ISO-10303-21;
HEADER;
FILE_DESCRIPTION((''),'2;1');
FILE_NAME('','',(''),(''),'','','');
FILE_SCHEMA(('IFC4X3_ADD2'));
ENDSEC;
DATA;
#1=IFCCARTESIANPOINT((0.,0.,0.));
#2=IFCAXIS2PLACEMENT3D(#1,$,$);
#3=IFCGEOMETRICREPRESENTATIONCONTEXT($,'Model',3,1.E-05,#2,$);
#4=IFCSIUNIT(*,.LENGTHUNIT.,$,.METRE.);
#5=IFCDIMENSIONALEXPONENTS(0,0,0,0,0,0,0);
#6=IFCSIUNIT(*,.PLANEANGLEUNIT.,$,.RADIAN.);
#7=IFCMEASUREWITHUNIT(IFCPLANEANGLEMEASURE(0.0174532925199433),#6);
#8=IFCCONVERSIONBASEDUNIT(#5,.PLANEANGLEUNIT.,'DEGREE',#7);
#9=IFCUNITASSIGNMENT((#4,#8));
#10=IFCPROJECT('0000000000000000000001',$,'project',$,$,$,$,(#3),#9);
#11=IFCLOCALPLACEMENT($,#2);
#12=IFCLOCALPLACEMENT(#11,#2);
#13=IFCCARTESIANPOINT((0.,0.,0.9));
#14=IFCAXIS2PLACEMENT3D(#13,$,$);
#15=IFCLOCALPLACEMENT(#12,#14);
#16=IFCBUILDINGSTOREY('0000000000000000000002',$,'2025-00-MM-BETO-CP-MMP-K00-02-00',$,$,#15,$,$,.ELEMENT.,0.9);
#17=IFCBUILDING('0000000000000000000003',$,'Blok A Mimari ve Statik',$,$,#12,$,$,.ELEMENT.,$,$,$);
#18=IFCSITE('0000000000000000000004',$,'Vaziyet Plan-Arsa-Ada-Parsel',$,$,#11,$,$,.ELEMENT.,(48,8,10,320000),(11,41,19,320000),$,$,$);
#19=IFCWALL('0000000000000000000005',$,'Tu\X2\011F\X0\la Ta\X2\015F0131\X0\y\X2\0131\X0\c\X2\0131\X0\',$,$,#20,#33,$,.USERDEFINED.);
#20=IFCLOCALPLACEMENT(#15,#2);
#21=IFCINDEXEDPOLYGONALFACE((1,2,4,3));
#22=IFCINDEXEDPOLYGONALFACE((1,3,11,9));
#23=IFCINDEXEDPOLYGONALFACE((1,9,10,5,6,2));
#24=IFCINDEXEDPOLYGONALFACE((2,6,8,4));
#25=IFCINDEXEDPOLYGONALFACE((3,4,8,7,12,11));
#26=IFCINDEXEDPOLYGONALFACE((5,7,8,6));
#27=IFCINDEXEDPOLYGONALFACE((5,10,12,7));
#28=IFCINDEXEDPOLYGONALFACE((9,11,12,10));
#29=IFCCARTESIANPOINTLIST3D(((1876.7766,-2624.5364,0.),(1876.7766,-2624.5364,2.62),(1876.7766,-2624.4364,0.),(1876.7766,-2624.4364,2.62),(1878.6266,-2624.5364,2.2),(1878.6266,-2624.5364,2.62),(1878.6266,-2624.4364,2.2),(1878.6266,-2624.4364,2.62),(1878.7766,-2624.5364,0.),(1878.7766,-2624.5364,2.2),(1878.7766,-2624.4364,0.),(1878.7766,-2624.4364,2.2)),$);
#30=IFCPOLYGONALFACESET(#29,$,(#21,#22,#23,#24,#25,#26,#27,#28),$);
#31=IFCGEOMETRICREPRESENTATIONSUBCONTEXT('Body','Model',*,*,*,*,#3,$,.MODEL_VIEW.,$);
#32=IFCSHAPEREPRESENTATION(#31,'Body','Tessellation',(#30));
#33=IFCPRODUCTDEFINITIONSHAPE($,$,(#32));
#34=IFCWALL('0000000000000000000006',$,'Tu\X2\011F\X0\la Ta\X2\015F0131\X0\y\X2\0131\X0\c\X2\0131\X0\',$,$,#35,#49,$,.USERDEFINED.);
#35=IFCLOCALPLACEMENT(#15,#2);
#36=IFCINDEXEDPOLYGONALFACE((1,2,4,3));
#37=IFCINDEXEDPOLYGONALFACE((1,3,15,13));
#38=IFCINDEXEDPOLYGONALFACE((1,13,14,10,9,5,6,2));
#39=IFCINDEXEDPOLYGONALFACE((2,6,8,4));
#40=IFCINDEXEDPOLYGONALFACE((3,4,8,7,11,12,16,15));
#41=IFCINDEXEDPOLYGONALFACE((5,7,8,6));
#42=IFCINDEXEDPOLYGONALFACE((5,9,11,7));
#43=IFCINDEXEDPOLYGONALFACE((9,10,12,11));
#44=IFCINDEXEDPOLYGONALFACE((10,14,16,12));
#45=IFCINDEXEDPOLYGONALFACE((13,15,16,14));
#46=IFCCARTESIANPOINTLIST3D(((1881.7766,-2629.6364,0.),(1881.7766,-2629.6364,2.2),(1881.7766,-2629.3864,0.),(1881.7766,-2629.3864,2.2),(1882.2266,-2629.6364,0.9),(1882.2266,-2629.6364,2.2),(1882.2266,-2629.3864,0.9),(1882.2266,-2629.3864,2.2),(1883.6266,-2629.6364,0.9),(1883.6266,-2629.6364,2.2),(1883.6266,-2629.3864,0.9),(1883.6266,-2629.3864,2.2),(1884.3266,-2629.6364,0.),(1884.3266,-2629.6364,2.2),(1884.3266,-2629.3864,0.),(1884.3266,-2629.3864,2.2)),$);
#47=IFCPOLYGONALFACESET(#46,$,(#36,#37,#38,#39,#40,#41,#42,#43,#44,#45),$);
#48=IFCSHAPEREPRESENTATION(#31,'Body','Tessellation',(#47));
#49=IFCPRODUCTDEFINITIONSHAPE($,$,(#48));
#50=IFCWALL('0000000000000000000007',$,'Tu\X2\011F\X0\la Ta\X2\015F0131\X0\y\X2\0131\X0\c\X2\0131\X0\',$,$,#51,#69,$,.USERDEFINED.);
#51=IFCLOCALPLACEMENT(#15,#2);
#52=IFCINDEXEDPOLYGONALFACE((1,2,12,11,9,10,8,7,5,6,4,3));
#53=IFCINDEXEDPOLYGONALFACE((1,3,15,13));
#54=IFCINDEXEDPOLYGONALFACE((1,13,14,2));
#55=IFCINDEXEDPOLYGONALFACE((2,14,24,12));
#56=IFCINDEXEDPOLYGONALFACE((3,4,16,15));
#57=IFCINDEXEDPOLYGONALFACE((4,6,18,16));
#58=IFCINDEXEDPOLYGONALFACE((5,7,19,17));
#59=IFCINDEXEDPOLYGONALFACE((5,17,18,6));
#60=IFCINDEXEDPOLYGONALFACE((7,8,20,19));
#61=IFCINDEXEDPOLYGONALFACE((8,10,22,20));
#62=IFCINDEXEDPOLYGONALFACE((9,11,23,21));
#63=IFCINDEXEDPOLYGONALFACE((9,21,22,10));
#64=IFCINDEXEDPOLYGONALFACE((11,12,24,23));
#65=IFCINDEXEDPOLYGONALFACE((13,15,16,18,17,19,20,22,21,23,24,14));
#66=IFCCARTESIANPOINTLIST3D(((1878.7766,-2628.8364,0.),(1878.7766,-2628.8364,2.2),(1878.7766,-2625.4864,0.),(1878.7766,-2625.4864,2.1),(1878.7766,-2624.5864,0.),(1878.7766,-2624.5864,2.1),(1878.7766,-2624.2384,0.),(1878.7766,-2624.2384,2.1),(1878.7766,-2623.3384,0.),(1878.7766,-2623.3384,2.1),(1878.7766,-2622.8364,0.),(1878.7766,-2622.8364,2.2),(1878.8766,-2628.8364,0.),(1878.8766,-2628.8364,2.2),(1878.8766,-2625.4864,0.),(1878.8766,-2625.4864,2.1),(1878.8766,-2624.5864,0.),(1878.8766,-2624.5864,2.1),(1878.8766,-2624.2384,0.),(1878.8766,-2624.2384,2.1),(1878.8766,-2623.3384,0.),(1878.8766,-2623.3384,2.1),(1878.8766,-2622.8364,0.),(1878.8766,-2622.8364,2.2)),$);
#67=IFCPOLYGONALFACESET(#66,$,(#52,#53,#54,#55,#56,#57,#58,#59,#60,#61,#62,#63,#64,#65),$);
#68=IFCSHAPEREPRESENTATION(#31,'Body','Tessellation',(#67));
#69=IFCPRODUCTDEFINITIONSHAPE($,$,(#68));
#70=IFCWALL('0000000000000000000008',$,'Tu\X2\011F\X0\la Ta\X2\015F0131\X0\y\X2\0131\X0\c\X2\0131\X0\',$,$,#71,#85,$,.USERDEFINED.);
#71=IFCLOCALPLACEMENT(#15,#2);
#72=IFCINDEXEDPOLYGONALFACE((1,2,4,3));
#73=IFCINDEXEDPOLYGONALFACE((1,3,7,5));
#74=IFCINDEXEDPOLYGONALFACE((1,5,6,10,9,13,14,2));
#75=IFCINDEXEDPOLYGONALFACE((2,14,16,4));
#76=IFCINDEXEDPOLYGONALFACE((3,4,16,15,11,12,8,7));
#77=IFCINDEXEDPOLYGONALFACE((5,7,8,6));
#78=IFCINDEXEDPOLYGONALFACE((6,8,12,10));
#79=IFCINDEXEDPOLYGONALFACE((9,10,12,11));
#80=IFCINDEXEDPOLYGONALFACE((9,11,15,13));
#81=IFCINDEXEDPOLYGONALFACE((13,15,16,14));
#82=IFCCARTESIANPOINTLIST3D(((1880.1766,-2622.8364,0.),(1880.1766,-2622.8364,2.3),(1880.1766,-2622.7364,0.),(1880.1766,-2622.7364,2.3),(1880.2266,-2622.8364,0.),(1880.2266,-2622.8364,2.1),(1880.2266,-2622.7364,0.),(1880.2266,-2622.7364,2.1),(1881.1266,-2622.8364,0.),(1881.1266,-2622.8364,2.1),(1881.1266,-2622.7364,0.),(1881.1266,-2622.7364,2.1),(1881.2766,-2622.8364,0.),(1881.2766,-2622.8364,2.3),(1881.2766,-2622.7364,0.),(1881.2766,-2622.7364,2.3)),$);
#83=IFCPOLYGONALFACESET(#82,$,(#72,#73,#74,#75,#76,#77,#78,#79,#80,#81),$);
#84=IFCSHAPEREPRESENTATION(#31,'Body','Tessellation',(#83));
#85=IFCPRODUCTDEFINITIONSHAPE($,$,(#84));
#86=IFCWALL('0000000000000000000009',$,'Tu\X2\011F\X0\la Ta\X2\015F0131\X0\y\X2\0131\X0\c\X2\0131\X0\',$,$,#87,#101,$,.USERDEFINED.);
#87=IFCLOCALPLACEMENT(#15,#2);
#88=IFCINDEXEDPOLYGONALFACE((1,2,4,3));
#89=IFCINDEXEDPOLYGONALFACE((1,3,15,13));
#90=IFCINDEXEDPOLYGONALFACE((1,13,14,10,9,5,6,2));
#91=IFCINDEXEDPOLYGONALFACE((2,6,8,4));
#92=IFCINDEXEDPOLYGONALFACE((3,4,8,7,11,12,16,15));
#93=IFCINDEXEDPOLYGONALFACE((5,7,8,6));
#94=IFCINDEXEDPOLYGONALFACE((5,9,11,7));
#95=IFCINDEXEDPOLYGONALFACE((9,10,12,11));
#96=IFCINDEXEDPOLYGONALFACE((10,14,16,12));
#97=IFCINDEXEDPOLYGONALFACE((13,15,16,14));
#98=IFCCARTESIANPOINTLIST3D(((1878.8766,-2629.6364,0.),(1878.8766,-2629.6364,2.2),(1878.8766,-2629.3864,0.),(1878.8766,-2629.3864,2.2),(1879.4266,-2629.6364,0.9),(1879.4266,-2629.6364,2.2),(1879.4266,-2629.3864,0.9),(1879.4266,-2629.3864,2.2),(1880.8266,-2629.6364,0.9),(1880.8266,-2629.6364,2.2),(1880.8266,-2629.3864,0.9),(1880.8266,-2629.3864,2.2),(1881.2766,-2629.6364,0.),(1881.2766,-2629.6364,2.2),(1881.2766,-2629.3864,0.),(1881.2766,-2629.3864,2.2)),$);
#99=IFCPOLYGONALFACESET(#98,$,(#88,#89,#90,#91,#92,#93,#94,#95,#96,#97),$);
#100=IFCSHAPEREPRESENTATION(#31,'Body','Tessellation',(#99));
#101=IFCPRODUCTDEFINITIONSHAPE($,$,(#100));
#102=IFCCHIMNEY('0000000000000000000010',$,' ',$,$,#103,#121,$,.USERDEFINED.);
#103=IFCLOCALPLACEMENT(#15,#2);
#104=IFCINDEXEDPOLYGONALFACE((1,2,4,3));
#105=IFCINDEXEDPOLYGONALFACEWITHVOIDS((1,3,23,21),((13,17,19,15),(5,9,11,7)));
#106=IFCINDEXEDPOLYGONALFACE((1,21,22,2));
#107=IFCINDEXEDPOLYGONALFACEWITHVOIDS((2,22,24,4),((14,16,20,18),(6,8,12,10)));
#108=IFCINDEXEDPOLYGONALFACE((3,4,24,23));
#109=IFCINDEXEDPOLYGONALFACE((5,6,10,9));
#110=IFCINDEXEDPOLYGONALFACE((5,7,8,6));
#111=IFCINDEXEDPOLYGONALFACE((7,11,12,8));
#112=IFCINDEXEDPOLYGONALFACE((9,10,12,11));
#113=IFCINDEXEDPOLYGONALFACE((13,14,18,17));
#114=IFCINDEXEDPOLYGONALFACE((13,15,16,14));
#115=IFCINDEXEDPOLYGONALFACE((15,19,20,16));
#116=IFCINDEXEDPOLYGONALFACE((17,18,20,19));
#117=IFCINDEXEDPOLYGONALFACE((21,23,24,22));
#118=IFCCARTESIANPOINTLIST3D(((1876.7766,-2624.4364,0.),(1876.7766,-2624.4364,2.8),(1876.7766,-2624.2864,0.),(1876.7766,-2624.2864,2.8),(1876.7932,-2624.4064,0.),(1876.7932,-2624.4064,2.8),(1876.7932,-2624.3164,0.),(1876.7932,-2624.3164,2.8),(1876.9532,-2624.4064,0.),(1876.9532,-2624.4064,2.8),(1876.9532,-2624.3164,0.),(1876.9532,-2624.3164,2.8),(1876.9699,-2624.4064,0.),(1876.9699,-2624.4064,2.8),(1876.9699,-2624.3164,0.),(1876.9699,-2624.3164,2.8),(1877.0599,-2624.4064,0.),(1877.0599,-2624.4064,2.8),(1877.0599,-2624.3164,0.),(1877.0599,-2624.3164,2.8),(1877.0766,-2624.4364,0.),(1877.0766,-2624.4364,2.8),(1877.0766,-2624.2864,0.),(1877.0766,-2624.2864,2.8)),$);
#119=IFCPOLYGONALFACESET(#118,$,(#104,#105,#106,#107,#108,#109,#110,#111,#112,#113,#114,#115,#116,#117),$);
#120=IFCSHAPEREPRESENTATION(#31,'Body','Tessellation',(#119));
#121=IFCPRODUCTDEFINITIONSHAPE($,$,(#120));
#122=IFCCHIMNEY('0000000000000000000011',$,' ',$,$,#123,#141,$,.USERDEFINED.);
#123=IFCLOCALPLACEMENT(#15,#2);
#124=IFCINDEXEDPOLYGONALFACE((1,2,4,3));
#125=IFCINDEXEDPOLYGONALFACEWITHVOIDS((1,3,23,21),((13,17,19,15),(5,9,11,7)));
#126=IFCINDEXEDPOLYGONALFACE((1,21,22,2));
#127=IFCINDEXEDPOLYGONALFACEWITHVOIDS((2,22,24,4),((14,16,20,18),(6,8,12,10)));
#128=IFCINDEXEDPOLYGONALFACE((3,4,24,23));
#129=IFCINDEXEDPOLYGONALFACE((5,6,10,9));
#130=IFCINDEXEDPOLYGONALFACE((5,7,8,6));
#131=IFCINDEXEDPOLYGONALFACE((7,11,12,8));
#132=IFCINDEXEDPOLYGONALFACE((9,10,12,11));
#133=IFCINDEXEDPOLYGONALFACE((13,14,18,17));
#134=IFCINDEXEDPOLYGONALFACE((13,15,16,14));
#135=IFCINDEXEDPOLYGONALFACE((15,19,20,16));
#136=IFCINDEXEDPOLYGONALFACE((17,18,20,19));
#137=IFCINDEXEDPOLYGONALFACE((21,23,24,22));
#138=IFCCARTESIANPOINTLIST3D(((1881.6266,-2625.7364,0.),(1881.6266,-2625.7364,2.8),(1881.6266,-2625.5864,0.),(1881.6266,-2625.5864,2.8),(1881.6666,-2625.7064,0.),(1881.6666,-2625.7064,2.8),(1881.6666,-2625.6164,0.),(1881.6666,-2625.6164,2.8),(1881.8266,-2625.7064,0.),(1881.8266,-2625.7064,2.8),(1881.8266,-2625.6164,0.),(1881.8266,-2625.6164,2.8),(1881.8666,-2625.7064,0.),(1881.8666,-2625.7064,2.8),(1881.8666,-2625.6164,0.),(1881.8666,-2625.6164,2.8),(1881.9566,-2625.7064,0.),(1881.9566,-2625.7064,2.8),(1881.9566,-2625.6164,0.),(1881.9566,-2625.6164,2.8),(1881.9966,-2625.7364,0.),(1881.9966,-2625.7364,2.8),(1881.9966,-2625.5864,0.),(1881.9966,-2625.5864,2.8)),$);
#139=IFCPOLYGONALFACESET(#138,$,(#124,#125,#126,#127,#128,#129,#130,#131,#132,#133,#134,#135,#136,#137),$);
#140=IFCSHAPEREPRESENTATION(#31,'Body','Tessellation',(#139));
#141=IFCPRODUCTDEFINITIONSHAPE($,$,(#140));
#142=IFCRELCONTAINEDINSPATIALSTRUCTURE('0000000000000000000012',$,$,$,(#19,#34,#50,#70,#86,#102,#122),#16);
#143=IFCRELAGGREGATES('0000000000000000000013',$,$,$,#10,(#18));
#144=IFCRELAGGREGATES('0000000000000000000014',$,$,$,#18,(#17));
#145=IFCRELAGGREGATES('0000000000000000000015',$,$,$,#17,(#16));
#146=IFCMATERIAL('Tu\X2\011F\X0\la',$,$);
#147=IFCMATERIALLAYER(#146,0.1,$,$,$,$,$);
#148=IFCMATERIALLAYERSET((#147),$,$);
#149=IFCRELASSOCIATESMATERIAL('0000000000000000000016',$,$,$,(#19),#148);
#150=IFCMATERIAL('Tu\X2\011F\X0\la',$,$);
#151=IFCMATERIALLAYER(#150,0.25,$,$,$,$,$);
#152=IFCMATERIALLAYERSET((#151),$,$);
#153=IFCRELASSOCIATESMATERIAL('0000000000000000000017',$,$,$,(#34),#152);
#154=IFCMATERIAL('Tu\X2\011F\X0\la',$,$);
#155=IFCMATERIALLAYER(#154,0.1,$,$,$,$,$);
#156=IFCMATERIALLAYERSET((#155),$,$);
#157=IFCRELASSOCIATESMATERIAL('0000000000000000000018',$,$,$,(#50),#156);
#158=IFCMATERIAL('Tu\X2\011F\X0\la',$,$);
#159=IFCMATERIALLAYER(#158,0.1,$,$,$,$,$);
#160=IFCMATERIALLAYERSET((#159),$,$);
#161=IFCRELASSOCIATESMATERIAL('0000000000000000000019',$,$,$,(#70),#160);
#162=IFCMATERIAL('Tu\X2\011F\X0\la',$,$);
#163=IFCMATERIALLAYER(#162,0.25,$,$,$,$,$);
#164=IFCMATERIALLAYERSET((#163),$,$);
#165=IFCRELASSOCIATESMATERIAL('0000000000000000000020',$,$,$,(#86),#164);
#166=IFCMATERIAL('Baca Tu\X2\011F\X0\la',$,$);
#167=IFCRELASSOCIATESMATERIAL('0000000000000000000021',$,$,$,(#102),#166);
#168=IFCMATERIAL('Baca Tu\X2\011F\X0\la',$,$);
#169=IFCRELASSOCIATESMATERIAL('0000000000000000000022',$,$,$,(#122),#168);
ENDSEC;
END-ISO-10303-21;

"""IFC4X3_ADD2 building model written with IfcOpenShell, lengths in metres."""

from ifc_helpers import new_model, entity, si_unit, converted_unit, frame, frame_2d, origin, origin_with_axes, place, context, subcontext, project, spatial, polyline, rectangle, outline, extrude, clip, bounded_halfspace, material, layer, layer_set, layer_usage, element, save


model = new_model("IFC4X3_ADD2")

# Units and contexts
model_context = context("Model", 3, precision=1e-05, world=origin())
body_context = subcontext(model_context, "Body", "Model", "MODEL_VIEW")
ifc_project = project(units=[si_unit("LENGTHUNIT", "METRE"), converted_unit("PLANEANGLEUNIT", "DEGREE", entity("IfcPlaneAngleMeasure", 0.0174532925199433), si_unit("PLANEANGLEUNIT", "RADIAN"), dimensions=[0, 0, 0, 0, 0, 0, 0])], contexts=[model_context])

# Site, building, storey
site_placement = place(None, origin())
site = spatial("IfcSite", under=ifc_project, at=site_placement, Name="Vaziyet Plan-Arsa-Ada-Parsel", CompositionType="ELEMENT", RefLatitude=(48, 8, 10, 320000), RefLongitude=(11, 41, 19, 320000))
building_placement = place(site_placement, origin())
building = spatial("IfcBuilding", under=site, at=building_placement, Name="Blok A Mimari ve Statik", CompositionType="ELEMENT")
storey_placement = place(building_placement, frame((0.0, 0.0, 0.9)))
storey = spatial("IfcBuildingStorey", under=building, at=storey_placement, Name="2025-00-MM-BETO-CP-MMP-K00-02-00", CompositionType="ELEMENT", Elevation=0.9)

# Wall
ifc_material_1 = material(Name="Tuğla")
ifc_layer_1 = layer(ifc_material_1, 0.1)
ifc_layer_set_1 = layer_set([ifc_layer_1])
ifc_layer_usage_1 = layer_usage(ifc_layer_set_1, "AXIS2", "POSITIVE", 0.0)
wall_1_placement = place(storey_placement, frame((1876.7766, -2624.5364, 0.0)))
element("IfcWall", 1, at=wall_1_placement, inside=storey, material=ifc_layer_usage_1, Name="Tuğla Taşıyıcı", PredefinedType="USERDEFINED", context=body_context, shape_type="Clipping", body=[
    clip(extrude(rectangle(XDim=2.0, YDim=0.1, at=frame_2d((1.0, 0.05), x_axis=(1.0, 0.0))), origin_with_axes(), (0.0, 0.0, 1.0), 2.62), bounded_halfspace(frame((1.925, 0.05, 2.2), z_axis=(0.0, 0.0, -1.0), x_axis=(0.0, -1.0, 0.0)), True, origin_with_axes(), polyline([(1.85, 0.1), (1.85, 0.0), (2.0, 0.0), (2.0, 0.1), (1.85, 0.1)]))),
])

# Wall, opening
ifc_material_2 = material(Name="Tuğla")
ifc_layer_2 = layer(ifc_material_2, 0.25)
ifc_layer_set_2 = layer_set([ifc_layer_2])
ifc_layer_usage_2 = layer_usage(ifc_layer_set_2, "AXIS2", "POSITIVE", 0.0)
wall_2_placement = place(storey_placement, frame((1881.7766, -2629.6364, 0.0), z_axis=(0.0, 0.0, 1.0), x_axis=(1.0, 0.0, 0.0)))
wall_2 = element("IfcWall", 2, at=wall_2_placement, inside=storey, material=ifc_layer_usage_2, Name="Tuğla Taşıyıcı", PredefinedType="USERDEFINED", context=body_context, shape_type="SweptSolid", body=[
    extrude(rectangle(XDim=2.55, YDim=0.25, at=frame_2d((1.275, 0.125), x_axis=(1.0, 0.0))), origin_with_axes(), (0.0, 0.0, 1.0), 2.2),
])
opening_1_placement = place(wall_2_placement, frame((0.45, 0.0, 0.9), z_axis=(0.0, 1.0, 0.0), x_axis=(0.0, 0.0, 1.0)))
element("IfcOpeningElement", 3, at=opening_1_placement, cuts=wall_2, PredefinedType="OPENING", context=body_context, shape_type="SweptSolid", body=[
    extrude(outline(polyline([(1.35, 1.4), (1.35, 0.0), (0.0, 0.0), (0.0, 1.4), (1.35, 1.4)])), origin_with_axes(), (0.0, 0.0, 1.0), 0.25),
])

# Wall, openings
ifc_material_3 = material(Name="Tuğla")
ifc_layer_3 = layer(ifc_material_3, 0.1)
ifc_layer_set_3 = layer_set([ifc_layer_3])
ifc_layer_usage_3 = layer_usage(ifc_layer_set_3, "AXIS2", "POSITIVE", 0.0)
wall_3_placement = place(storey_placement, frame((1878.8766, -2628.8364, 0.0), z_axis=(0.0, 0.0, 1.0), x_axis=(0.0, 1.0, 0.0)))
wall_3 = element("IfcWall", 4, at=wall_3_placement, inside=storey, material=ifc_layer_usage_3, Name="Tuğla Taşıyıcı", PredefinedType="USERDEFINED", context=body_context, shape_type="SweptSolid", body=[
    extrude(rectangle(XDim=6.0, YDim=0.1, at=frame_2d((3.0, 0.05), x_axis=(1.0, 0.0))), origin_with_axes(), (0.0, 0.0, 1.0), 2.2),
])
opening_2_placement = place(wall_3_placement, frame((4.25, 0.1, 0.0), z_axis=(0.0, -1.0, 0.0), x_axis=(0.0, 0.0, 1.0)))
element("IfcOpeningElement", 5, at=opening_2_placement, cuts=wall_3, PredefinedType="OPENING", context=body_context, shape_type="SweptSolid", body=[
    extrude(outline(polyline([(2.1, 0.9), (2.1, 0.0), (0.0, 0.0), (0.0, 0.9), (2.1, 0.9)])), origin_with_axes(), (0.0, 0.0, 1.0), 0.1),
])
opening_3_placement = place(wall_3_placement, frame((5.498, 0.1, 0.0), z_axis=(0.0, -1.0, 0.0), x_axis=(0.0, 0.0, 1.0)))
element("IfcOpeningElement", 6, at=opening_3_placement, cuts=wall_3, PredefinedType="OPENING", context=body_context, shape_type="SweptSolid", body=[
    extrude(outline(polyline([(2.1, 0.9), (2.1, 0.0), (0.0, 0.0), (0.0, 0.9), (2.1, 0.9)])), origin_with_axes(), (0.0, 0.0, 1.0), 0.1),
])

# Walls, openings
ifc_material_4 = material(Name="Tuğla")
ifc_layer_4 = layer(ifc_material_4, 0.1)
ifc_layer_set_4 = layer_set([ifc_layer_4])
ifc_layer_usage_4 = layer_usage(ifc_layer_set_4, "AXIS2", "POSITIVE", 0.0)
wall_4_placement = place(storey_placement, frame((1880.1766, -2622.8364, 0.0), z_axis=(0.0, 0.0, 1.0), x_axis=(1.0, -0.000001, 0.0)))
wall_4 = element("IfcWall", 7, at=wall_4_placement, inside=storey, material=ifc_layer_usage_4, Name="Tuğla Taşıyıcı", PredefinedType="USERDEFINED", context=body_context, shape_type="SweptSolid", body=[
    extrude(rectangle(XDim=1.1, YDim=0.1, at=frame_2d((0.55, 0.05), x_axis=(1.0, 0.0))), origin_with_axes(), (0.0, 0.0, 1.0), 2.3),
])
opening_4_placement = place(wall_4_placement, frame((0.05, 0.0, 0.0), z_axis=(0.0, 1.0, 0.0), x_axis=(0.0, 0.0, 1.0)))
element("IfcOpeningElement", 8, at=opening_4_placement, cuts=wall_4, PredefinedType="OPENING", context=body_context, shape_type="SweptSolid", body=[
    extrude(outline(polyline([(2.1, 0.9), (2.1, 0.0), (0.0, 0.0), (0.0, 0.9), (2.1, 0.9)])), origin_with_axes(), (0.0, 0.0, 1.0), 0.1),
])
ifc_material_5 = material(Name="Tuğla")
ifc_layer_5 = layer(ifc_material_5, 0.25)
ifc_layer_set_5 = layer_set([ifc_layer_5])
ifc_layer_usage_5 = layer_usage(ifc_layer_set_5, "AXIS2", "POSITIVE", 0.0)
wall_5_placement = place(storey_placement, frame((1878.8766, -2629.6364, 0.0)))
wall_5 = element("IfcWall", 9, at=wall_5_placement, inside=storey, material=ifc_layer_usage_5, Name="Tuğla Taşıyıcı", PredefinedType="USERDEFINED", context=body_context, shape_type="SweptSolid", body=[
    extrude(rectangle(XDim=2.4, YDim=0.25, at=frame_2d((1.2, 0.125), x_axis=(1.0, 0.0))), origin_with_axes(), (0.0, 0.0, 1.0), 2.2),
])
opening_5_placement = place(wall_5_placement, frame((0.55, 0.0, 0.9), z_axis=(0.0, 1.0, 0.0), x_axis=(0.0, 0.0, 1.0)))
element("IfcOpeningElement", 10, at=opening_5_placement, cuts=wall_5, PredefinedType="OPENING", context=body_context, shape_type="SweptSolid", body=[
    extrude(outline(polyline([(1.35, 1.4), (1.35, 0.0), (0.0, 0.0), (0.0, 1.4), (1.35, 1.4)])), origin_with_axes(), (0.0, 0.0, 1.0), 0.25),
])

# Chimneys
ifc_material_6 = material(Name="Baca Tuğla")
chimney_1_placement = place(storey_placement, frame((1876.7766, -2624.4364, 0.0)))
element("IfcChimney", 11, at=chimney_1_placement, inside=storey, material=ifc_material_6, Name=" ", PredefinedType="USERDEFINED", context=body_context, shape_type="SweptSolid", body=[
    extrude(outline(polyline([(0.0, 0.0), (0.3, 0.0), (0.3, 0.15), (0.0, 0.15), (0.0, 0.0)]), holes=[polyline([(0.1933, 0.03), (0.1933, 0.12), (0.2833, 0.12), (0.2833, 0.03), (0.1933, 0.03)]), polyline([(0.0167, 0.03), (0.0167, 0.12), (0.1767, 0.12), (0.1767, 0.03), (0.0167, 0.03)])]), origin_with_axes(), (0.0, 0.0, 1.0), 2.8),
])
ifc_material_7 = material(Name="Baca Tuğla")
chimney_2_placement = place(storey_placement, frame((1881.6266, -2625.7364, 0.0)))
element("IfcChimney", 12, at=chimney_2_placement, inside=storey, material=ifc_material_7, Name=" ", PredefinedType="USERDEFINED", context=body_context, shape_type="SweptSolid", body=[
    extrude(outline(polyline([(0.0, 0.0), (0.37, 0.0), (0.37, 0.15), (0.0, 0.15), (0.0, 0.0)]), holes=[polyline([(0.24, 0.03), (0.24, 0.12), (0.33, 0.12), (0.33, 0.03), (0.24, 0.03)]), polyline([(0.04, 0.03), (0.04, 0.12), (0.2, 0.12), (0.2, 0.03), (0.04, 0.03)])]), origin_with_axes(), (0.0, 0.0, 1.0), 2.8),
])

save(model, "model.ifc")
